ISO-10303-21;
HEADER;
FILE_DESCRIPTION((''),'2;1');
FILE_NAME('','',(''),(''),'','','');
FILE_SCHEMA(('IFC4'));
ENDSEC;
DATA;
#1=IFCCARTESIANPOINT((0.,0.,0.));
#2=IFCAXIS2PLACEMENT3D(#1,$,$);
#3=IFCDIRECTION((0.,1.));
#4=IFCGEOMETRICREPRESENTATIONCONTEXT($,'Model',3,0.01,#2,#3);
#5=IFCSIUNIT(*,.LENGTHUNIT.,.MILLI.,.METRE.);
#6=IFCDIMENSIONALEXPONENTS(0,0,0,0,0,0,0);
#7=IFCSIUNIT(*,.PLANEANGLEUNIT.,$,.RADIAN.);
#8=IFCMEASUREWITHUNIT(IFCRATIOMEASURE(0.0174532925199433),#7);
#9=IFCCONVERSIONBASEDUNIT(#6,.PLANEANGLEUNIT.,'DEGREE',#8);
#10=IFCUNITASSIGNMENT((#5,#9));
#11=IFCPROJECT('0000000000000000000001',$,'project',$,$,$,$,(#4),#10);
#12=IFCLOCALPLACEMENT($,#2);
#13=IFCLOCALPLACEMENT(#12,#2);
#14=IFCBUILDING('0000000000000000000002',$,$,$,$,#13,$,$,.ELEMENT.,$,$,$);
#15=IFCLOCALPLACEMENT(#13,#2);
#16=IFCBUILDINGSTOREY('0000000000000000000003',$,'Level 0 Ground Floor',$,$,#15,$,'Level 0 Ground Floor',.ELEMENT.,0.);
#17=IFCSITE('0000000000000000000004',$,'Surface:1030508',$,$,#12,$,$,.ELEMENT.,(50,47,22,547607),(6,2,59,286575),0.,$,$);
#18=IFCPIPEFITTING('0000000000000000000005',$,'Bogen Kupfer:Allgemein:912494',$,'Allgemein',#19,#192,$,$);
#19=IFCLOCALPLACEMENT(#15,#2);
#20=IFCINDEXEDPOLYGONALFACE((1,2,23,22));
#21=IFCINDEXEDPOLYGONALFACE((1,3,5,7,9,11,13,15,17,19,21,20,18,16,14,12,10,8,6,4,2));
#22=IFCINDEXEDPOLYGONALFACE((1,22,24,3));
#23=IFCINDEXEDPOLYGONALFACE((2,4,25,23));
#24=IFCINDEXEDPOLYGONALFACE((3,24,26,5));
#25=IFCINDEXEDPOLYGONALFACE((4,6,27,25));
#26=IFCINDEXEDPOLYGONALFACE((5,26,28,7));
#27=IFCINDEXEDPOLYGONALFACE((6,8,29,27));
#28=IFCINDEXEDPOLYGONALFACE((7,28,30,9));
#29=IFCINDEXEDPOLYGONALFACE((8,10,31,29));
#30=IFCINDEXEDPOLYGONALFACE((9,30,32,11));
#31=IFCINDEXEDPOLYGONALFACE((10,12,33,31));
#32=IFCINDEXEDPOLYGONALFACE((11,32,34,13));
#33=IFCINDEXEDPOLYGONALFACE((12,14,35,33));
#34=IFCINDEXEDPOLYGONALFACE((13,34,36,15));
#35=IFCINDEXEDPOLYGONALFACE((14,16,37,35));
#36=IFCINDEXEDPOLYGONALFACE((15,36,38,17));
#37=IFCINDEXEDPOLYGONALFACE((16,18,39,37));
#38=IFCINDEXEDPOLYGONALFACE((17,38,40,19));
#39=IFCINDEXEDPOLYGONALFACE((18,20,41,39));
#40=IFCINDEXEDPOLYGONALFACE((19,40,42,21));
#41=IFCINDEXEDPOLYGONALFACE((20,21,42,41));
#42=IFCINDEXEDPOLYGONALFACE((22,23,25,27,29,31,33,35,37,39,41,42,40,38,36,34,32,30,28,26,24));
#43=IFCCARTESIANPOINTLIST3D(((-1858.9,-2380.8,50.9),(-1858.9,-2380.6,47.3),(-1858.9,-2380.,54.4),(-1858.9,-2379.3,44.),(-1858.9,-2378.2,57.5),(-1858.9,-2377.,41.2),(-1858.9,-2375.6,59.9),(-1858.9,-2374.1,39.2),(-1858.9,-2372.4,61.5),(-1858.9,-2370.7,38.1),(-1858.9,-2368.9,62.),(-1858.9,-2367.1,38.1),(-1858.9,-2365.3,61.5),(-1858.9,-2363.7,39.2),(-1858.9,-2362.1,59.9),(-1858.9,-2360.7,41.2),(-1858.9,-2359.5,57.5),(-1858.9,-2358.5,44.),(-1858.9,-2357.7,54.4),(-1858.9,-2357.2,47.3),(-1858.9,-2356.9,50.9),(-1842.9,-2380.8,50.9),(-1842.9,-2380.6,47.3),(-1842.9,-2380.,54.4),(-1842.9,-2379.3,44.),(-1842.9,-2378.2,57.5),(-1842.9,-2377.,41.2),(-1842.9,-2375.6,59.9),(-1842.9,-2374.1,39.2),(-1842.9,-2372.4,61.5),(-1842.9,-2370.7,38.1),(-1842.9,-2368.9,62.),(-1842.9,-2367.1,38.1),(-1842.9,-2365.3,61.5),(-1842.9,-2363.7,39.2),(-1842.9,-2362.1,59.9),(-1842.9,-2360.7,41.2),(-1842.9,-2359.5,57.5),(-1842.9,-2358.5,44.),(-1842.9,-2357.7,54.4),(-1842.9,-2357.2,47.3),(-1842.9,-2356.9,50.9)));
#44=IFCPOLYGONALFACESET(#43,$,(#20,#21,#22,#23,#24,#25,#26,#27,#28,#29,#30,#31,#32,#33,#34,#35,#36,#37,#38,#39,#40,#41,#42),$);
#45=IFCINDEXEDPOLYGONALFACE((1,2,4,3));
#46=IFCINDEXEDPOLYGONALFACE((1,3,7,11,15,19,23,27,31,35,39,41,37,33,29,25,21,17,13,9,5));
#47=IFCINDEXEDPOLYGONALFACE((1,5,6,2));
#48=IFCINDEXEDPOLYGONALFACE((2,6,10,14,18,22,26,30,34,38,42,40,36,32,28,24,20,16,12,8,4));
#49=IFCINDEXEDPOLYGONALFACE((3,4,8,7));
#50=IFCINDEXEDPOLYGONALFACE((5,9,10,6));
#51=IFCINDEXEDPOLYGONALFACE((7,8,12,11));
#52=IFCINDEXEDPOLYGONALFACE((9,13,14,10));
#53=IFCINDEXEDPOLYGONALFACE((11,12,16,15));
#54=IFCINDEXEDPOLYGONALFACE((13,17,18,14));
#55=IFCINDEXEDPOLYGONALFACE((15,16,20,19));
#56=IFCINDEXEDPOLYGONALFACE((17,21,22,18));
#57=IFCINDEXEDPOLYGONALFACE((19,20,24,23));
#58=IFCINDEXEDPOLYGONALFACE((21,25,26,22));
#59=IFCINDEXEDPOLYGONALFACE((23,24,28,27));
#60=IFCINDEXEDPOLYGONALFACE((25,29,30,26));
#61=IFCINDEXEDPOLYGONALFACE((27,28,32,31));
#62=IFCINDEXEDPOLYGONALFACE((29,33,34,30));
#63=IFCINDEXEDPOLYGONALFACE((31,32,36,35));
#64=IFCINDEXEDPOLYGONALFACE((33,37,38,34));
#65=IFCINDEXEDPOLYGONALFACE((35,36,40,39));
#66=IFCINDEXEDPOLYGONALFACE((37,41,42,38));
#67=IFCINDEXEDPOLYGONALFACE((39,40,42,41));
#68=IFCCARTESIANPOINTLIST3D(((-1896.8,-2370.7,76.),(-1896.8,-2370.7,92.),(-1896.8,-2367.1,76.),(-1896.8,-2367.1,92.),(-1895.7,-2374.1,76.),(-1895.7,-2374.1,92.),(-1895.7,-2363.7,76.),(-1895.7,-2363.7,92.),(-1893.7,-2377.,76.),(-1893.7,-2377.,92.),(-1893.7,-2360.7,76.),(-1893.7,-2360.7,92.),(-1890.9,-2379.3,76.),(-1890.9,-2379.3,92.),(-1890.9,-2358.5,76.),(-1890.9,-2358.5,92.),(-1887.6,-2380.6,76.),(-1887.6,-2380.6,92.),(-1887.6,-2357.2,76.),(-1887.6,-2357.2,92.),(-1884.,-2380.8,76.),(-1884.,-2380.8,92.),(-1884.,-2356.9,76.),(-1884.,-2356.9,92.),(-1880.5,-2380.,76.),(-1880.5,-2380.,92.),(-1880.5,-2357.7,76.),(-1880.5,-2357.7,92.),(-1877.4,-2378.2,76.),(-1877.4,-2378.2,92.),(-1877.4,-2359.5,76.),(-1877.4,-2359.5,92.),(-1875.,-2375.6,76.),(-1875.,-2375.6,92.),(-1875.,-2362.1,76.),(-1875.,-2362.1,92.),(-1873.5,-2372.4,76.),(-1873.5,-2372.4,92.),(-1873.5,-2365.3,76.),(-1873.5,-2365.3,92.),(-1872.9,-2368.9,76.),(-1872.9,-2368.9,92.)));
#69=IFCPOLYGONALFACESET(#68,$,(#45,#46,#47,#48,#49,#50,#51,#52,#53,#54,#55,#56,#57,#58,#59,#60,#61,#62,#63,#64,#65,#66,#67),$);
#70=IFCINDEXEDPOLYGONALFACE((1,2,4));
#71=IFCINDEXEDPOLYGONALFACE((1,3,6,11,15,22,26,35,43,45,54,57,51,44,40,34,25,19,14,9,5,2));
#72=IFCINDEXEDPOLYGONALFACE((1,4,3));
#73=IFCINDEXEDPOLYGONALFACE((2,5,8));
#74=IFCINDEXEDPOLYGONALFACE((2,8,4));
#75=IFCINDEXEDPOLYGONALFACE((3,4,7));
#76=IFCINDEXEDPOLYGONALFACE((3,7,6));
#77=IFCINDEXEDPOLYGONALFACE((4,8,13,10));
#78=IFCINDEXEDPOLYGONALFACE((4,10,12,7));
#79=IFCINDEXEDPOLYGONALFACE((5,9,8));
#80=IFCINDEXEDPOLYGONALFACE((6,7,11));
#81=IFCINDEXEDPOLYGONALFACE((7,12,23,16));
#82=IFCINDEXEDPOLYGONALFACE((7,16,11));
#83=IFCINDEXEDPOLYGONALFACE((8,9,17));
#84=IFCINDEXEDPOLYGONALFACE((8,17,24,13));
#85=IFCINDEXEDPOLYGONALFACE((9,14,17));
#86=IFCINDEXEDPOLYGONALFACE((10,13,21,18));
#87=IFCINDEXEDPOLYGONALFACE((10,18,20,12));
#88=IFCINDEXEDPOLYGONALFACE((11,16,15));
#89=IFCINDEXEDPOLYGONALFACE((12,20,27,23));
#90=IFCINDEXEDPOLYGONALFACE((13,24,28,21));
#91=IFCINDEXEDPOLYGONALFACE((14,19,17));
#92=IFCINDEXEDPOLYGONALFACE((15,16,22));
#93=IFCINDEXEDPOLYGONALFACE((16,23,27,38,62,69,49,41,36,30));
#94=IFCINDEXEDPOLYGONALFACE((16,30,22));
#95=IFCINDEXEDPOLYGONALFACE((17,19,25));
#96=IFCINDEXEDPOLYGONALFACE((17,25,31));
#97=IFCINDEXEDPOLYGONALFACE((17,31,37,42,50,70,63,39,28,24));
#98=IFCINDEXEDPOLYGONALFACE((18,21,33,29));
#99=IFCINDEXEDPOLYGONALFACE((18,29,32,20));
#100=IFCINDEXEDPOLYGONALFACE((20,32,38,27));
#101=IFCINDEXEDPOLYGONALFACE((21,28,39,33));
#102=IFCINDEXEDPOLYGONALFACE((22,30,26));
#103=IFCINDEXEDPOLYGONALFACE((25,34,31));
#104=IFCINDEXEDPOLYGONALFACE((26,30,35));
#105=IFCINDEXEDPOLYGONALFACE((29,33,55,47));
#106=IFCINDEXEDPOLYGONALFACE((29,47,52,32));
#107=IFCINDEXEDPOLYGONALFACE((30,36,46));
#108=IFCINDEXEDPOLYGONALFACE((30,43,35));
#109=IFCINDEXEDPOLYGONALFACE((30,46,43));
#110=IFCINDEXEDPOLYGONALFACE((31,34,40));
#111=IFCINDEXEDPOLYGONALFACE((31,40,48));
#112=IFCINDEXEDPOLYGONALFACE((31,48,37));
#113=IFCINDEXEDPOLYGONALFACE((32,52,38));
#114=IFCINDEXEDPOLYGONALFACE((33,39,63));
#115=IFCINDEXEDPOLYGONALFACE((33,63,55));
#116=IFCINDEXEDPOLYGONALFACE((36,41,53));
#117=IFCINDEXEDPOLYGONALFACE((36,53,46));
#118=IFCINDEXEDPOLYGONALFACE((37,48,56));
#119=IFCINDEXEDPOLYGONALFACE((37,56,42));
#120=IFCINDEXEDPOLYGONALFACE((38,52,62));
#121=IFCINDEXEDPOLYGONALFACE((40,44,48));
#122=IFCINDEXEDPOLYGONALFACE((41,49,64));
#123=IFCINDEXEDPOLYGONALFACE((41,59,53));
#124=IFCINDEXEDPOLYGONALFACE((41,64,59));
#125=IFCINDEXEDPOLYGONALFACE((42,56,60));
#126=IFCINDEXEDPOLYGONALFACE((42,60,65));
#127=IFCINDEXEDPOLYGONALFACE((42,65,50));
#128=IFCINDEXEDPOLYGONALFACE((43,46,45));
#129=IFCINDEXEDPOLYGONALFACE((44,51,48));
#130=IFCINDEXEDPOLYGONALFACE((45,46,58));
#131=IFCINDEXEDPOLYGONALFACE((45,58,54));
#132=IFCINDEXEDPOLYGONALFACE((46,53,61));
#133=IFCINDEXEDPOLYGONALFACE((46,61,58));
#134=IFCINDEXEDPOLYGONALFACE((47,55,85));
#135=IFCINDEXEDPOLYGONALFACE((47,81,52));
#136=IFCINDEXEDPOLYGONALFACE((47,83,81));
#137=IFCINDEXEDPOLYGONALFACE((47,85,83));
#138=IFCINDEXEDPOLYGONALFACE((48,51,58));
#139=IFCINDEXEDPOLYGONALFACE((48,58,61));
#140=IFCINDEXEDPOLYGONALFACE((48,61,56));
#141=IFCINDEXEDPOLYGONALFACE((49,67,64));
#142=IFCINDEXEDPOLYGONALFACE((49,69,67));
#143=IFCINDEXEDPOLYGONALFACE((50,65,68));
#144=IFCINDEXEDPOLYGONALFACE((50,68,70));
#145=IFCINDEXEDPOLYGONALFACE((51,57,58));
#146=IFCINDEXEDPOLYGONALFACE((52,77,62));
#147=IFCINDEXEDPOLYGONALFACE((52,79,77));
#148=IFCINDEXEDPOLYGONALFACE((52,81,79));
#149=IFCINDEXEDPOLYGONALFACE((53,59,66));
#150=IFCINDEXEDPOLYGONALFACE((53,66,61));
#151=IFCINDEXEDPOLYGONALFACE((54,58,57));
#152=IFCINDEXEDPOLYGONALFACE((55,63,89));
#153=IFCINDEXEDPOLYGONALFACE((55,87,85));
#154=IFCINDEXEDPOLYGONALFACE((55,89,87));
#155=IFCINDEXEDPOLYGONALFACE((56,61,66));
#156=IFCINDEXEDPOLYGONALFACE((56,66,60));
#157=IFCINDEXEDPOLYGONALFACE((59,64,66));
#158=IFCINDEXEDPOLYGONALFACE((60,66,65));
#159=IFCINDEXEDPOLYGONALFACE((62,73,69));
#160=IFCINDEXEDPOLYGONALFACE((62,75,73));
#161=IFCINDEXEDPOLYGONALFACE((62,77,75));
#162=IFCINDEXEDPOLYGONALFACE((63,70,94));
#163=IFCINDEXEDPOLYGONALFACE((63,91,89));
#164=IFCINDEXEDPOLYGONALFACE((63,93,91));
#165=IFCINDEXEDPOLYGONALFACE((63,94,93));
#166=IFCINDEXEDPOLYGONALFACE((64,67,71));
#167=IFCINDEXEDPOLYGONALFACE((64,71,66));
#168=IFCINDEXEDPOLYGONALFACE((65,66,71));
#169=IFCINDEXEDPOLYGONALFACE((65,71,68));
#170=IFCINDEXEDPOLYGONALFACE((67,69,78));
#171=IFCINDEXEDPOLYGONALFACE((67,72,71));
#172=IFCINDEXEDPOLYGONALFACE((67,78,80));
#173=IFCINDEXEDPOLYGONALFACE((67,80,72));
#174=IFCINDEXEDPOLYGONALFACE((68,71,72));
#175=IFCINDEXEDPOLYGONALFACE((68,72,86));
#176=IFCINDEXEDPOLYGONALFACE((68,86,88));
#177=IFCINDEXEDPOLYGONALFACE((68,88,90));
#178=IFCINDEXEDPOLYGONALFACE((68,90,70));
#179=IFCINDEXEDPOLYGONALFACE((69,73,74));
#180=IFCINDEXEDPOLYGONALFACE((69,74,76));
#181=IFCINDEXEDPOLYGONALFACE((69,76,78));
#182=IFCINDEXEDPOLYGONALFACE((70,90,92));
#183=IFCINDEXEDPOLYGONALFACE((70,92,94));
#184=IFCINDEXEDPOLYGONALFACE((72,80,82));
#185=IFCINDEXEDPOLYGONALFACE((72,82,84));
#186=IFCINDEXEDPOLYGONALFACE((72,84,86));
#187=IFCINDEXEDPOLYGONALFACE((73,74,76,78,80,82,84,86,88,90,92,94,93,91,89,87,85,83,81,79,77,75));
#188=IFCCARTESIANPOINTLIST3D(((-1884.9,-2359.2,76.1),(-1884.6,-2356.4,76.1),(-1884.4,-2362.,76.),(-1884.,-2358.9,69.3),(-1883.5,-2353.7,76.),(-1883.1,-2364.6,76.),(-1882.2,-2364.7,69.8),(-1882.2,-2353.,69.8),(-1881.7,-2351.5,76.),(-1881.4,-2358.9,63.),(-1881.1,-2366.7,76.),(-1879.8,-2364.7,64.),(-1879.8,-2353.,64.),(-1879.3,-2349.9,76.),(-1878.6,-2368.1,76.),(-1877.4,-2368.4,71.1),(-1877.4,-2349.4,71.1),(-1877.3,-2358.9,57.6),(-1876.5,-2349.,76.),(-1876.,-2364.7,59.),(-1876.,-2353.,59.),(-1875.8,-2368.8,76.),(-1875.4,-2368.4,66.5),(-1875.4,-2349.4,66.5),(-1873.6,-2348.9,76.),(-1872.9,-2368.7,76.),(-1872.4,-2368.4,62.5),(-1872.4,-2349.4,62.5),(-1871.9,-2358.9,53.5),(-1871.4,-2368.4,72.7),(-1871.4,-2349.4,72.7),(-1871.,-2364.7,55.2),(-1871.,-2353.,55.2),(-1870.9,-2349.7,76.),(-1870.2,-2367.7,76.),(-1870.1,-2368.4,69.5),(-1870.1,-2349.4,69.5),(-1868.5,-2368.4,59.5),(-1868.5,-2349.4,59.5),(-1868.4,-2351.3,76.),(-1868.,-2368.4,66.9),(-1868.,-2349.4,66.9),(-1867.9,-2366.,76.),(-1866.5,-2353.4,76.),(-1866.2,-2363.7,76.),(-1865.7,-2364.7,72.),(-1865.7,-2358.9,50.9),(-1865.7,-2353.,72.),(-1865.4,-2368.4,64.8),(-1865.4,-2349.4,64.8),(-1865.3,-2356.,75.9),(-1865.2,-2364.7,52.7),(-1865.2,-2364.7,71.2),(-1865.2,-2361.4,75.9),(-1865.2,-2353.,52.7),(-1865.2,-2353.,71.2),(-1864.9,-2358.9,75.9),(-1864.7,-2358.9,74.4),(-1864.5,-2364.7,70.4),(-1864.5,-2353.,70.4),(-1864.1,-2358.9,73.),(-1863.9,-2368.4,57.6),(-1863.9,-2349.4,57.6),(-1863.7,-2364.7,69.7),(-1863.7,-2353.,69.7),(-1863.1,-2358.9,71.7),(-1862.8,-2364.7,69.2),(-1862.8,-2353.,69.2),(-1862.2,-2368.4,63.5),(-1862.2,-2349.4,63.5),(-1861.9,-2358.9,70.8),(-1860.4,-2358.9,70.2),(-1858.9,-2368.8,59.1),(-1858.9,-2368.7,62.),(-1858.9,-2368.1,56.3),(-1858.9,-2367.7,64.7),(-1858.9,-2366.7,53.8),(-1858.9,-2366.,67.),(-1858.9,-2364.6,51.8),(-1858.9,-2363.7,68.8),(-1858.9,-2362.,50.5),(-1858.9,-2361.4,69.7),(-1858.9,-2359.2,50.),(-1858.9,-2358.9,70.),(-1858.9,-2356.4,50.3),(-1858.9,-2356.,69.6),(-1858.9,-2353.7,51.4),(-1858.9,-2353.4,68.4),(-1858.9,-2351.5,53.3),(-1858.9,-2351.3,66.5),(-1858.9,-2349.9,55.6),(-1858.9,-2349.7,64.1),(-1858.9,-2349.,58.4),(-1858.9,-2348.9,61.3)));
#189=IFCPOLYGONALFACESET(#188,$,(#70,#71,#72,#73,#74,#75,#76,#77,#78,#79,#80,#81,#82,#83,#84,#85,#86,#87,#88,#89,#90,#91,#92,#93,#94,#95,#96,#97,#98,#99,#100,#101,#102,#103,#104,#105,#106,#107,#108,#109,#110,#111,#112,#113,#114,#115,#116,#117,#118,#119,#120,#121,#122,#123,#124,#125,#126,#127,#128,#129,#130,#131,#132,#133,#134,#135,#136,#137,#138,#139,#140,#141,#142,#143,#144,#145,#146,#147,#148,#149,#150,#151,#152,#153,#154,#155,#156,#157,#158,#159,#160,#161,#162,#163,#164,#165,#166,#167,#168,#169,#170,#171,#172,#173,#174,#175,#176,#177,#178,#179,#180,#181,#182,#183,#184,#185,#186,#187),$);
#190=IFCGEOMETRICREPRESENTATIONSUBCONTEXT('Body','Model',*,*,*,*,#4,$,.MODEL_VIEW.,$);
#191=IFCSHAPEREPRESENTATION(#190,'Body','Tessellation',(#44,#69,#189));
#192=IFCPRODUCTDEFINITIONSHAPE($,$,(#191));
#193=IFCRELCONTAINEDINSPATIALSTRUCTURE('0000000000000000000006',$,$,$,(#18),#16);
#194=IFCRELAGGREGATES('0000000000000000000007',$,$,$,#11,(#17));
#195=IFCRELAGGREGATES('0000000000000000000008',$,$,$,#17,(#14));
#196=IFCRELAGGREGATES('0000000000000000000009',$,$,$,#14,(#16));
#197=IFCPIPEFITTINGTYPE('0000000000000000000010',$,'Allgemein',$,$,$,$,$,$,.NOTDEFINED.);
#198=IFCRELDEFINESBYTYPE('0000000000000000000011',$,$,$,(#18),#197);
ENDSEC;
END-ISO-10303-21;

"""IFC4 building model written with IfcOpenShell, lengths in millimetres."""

from ifc_helpers import new_model, entity, si_unit, converted_unit, direction, frame, frame_2d, origin, place, context, subcontext, project, spatial, circle, extrude, source, transform, mapped, type_object, type_shapes, element, save


model = new_model("IFC4")

# Units and contexts
model_context = context("Model", 3, precision=0.01, world=origin(), true_north=direction((0.0, 1.0)))
body_context = subcontext(model_context, "Body", "Model", "MODEL_VIEW")
ifc_project = project(units=[si_unit("LENGTHUNIT", "METRE", prefix="MILLI"), converted_unit("PLANEANGLEUNIT", "DEGREE", entity("IfcRatioMeasure", 0.0174532925199433), si_unit("PLANEANGLEUNIT", "RADIAN"), dimensions=[0, 0, 0, 0, 0, 0, 0])], contexts=[model_context])

# Site, building, storey
site_placement = place(None, origin())
site = spatial("IfcSite", under=ifc_project, at=site_placement, Name="Surface:1030508", CompositionType="ELEMENT", RefLatitude=(50, 47, 22, 547607), RefLongitude=(6, 2, 59, 286575), RefElevation=0.0)
building_placement = place(site_placement, origin())
building = spatial("IfcBuilding", under=site, at=building_placement, CompositionType="ELEMENT")
storey_placement = place(building_placement, origin())
storey = spatial("IfcBuildingStorey", under=building, at=storey_placement, Name="Level 0 Ground Floor", LongName="Level 0 Ground Floor", CompositionType="ELEMENT", Elevation=0.0)

# Pipe fitting
pipe_fitting_type_1 = type_object("IfcPipeFittingType", Name="Allgemein", PredefinedType="NOTDEFINED")
ifc_direction_1 = entity("IfcDirection", [0.0, 0.0, -1.0])
trimmed_curve_1 = entity("IfcTrimmedCurve", entity("IfcCircle", entity("IfcAxis2Placement2D", entity("IfcCartesianPoint", [-16.0, 0.0]), entity("IfcDirection", [0.0, 1.0])), 16.0), [entity("IfcParameterValue", 270.0)], [entity("IfcParameterValue", 0.0)], True, "PARAMETER")
shared_shape_1 = source(origin(), body_context, "Body", "SolidModel", [
    extrude(circle(Radius=12.0, at=frame_2d((0.0, 0.0), x_axis=(1.0, 0.0))), frame((0.0, 26.0, 0.0), z_axis=(0.0, 1.0, 0.0), x_axis=(-1.0, 0.0, 0.0)), (0.0, 0.0, 1.0), 16.0),
    extrude(circle(Radius=12.0, at=frame_2d((0.0, 0.0), x_axis=(1.0, 0.0))), frame((-42.0, 0.0, 0.0), z_axis=(1.0, 0.0, 0.0), x_axis=(0.0, 1.0, 0.0)), (0.0, 0.0, 1.0), 16.0),
    entity("IfcSurfaceCurveSweptAreaSolid", entity("IfcCircleProfileDef", "AREA", None, entity("IfcAxis2Placement2D", entity("IfcCartesianPoint", [0.0, 10.0]), entity("IfcDirection", [1.0, 0.0])), 10.0), entity("IfcAxis2Placement3D", entity("IfcCartesianPoint", [-10.0, 26.0, 0.0]), ifc_direction_1, entity("IfcDirection", [1.0, 0.0, 0.0])), trimmed_curve_1, 0.0, 90.0, entity("IfcSurfaceOfLinearExtrusion", entity("IfcArbitraryOpenProfileDef", "CURVE", None, trimmed_curve_1), entity("IfcAxis2Placement3D", entity("IfcCartesianPoint", [0.0, 0.0, -304.8])), ifc_direction_1, 1.0)),
])
type_shapes(pipe_fitting_type_1, [shared_shape_1])
for number, where, z_axis, x_axis, name in (
    (1, (-1884.9, -2368.9, 50.0), (0.0, -1.0, 0.0), (0.0, 0.0, -1.0), "Bogen Kupfer:Allgemein:912494"),
):
    element("IfcPipeFitting", number, at=place(storey_placement, frame(where, z_axis=z_axis, x_axis=x_axis)), inside=storey, type_object=pipe_fitting_type_1, Name=name, ObjectType="Allgemein", context=body_context, shape_type="MappedRepresentation", body=[
        mapped(shared_shape_1, transform((0.0, 0.0, 0.0), scale=1.0)),
    ])

save(model, "model.ifc")
